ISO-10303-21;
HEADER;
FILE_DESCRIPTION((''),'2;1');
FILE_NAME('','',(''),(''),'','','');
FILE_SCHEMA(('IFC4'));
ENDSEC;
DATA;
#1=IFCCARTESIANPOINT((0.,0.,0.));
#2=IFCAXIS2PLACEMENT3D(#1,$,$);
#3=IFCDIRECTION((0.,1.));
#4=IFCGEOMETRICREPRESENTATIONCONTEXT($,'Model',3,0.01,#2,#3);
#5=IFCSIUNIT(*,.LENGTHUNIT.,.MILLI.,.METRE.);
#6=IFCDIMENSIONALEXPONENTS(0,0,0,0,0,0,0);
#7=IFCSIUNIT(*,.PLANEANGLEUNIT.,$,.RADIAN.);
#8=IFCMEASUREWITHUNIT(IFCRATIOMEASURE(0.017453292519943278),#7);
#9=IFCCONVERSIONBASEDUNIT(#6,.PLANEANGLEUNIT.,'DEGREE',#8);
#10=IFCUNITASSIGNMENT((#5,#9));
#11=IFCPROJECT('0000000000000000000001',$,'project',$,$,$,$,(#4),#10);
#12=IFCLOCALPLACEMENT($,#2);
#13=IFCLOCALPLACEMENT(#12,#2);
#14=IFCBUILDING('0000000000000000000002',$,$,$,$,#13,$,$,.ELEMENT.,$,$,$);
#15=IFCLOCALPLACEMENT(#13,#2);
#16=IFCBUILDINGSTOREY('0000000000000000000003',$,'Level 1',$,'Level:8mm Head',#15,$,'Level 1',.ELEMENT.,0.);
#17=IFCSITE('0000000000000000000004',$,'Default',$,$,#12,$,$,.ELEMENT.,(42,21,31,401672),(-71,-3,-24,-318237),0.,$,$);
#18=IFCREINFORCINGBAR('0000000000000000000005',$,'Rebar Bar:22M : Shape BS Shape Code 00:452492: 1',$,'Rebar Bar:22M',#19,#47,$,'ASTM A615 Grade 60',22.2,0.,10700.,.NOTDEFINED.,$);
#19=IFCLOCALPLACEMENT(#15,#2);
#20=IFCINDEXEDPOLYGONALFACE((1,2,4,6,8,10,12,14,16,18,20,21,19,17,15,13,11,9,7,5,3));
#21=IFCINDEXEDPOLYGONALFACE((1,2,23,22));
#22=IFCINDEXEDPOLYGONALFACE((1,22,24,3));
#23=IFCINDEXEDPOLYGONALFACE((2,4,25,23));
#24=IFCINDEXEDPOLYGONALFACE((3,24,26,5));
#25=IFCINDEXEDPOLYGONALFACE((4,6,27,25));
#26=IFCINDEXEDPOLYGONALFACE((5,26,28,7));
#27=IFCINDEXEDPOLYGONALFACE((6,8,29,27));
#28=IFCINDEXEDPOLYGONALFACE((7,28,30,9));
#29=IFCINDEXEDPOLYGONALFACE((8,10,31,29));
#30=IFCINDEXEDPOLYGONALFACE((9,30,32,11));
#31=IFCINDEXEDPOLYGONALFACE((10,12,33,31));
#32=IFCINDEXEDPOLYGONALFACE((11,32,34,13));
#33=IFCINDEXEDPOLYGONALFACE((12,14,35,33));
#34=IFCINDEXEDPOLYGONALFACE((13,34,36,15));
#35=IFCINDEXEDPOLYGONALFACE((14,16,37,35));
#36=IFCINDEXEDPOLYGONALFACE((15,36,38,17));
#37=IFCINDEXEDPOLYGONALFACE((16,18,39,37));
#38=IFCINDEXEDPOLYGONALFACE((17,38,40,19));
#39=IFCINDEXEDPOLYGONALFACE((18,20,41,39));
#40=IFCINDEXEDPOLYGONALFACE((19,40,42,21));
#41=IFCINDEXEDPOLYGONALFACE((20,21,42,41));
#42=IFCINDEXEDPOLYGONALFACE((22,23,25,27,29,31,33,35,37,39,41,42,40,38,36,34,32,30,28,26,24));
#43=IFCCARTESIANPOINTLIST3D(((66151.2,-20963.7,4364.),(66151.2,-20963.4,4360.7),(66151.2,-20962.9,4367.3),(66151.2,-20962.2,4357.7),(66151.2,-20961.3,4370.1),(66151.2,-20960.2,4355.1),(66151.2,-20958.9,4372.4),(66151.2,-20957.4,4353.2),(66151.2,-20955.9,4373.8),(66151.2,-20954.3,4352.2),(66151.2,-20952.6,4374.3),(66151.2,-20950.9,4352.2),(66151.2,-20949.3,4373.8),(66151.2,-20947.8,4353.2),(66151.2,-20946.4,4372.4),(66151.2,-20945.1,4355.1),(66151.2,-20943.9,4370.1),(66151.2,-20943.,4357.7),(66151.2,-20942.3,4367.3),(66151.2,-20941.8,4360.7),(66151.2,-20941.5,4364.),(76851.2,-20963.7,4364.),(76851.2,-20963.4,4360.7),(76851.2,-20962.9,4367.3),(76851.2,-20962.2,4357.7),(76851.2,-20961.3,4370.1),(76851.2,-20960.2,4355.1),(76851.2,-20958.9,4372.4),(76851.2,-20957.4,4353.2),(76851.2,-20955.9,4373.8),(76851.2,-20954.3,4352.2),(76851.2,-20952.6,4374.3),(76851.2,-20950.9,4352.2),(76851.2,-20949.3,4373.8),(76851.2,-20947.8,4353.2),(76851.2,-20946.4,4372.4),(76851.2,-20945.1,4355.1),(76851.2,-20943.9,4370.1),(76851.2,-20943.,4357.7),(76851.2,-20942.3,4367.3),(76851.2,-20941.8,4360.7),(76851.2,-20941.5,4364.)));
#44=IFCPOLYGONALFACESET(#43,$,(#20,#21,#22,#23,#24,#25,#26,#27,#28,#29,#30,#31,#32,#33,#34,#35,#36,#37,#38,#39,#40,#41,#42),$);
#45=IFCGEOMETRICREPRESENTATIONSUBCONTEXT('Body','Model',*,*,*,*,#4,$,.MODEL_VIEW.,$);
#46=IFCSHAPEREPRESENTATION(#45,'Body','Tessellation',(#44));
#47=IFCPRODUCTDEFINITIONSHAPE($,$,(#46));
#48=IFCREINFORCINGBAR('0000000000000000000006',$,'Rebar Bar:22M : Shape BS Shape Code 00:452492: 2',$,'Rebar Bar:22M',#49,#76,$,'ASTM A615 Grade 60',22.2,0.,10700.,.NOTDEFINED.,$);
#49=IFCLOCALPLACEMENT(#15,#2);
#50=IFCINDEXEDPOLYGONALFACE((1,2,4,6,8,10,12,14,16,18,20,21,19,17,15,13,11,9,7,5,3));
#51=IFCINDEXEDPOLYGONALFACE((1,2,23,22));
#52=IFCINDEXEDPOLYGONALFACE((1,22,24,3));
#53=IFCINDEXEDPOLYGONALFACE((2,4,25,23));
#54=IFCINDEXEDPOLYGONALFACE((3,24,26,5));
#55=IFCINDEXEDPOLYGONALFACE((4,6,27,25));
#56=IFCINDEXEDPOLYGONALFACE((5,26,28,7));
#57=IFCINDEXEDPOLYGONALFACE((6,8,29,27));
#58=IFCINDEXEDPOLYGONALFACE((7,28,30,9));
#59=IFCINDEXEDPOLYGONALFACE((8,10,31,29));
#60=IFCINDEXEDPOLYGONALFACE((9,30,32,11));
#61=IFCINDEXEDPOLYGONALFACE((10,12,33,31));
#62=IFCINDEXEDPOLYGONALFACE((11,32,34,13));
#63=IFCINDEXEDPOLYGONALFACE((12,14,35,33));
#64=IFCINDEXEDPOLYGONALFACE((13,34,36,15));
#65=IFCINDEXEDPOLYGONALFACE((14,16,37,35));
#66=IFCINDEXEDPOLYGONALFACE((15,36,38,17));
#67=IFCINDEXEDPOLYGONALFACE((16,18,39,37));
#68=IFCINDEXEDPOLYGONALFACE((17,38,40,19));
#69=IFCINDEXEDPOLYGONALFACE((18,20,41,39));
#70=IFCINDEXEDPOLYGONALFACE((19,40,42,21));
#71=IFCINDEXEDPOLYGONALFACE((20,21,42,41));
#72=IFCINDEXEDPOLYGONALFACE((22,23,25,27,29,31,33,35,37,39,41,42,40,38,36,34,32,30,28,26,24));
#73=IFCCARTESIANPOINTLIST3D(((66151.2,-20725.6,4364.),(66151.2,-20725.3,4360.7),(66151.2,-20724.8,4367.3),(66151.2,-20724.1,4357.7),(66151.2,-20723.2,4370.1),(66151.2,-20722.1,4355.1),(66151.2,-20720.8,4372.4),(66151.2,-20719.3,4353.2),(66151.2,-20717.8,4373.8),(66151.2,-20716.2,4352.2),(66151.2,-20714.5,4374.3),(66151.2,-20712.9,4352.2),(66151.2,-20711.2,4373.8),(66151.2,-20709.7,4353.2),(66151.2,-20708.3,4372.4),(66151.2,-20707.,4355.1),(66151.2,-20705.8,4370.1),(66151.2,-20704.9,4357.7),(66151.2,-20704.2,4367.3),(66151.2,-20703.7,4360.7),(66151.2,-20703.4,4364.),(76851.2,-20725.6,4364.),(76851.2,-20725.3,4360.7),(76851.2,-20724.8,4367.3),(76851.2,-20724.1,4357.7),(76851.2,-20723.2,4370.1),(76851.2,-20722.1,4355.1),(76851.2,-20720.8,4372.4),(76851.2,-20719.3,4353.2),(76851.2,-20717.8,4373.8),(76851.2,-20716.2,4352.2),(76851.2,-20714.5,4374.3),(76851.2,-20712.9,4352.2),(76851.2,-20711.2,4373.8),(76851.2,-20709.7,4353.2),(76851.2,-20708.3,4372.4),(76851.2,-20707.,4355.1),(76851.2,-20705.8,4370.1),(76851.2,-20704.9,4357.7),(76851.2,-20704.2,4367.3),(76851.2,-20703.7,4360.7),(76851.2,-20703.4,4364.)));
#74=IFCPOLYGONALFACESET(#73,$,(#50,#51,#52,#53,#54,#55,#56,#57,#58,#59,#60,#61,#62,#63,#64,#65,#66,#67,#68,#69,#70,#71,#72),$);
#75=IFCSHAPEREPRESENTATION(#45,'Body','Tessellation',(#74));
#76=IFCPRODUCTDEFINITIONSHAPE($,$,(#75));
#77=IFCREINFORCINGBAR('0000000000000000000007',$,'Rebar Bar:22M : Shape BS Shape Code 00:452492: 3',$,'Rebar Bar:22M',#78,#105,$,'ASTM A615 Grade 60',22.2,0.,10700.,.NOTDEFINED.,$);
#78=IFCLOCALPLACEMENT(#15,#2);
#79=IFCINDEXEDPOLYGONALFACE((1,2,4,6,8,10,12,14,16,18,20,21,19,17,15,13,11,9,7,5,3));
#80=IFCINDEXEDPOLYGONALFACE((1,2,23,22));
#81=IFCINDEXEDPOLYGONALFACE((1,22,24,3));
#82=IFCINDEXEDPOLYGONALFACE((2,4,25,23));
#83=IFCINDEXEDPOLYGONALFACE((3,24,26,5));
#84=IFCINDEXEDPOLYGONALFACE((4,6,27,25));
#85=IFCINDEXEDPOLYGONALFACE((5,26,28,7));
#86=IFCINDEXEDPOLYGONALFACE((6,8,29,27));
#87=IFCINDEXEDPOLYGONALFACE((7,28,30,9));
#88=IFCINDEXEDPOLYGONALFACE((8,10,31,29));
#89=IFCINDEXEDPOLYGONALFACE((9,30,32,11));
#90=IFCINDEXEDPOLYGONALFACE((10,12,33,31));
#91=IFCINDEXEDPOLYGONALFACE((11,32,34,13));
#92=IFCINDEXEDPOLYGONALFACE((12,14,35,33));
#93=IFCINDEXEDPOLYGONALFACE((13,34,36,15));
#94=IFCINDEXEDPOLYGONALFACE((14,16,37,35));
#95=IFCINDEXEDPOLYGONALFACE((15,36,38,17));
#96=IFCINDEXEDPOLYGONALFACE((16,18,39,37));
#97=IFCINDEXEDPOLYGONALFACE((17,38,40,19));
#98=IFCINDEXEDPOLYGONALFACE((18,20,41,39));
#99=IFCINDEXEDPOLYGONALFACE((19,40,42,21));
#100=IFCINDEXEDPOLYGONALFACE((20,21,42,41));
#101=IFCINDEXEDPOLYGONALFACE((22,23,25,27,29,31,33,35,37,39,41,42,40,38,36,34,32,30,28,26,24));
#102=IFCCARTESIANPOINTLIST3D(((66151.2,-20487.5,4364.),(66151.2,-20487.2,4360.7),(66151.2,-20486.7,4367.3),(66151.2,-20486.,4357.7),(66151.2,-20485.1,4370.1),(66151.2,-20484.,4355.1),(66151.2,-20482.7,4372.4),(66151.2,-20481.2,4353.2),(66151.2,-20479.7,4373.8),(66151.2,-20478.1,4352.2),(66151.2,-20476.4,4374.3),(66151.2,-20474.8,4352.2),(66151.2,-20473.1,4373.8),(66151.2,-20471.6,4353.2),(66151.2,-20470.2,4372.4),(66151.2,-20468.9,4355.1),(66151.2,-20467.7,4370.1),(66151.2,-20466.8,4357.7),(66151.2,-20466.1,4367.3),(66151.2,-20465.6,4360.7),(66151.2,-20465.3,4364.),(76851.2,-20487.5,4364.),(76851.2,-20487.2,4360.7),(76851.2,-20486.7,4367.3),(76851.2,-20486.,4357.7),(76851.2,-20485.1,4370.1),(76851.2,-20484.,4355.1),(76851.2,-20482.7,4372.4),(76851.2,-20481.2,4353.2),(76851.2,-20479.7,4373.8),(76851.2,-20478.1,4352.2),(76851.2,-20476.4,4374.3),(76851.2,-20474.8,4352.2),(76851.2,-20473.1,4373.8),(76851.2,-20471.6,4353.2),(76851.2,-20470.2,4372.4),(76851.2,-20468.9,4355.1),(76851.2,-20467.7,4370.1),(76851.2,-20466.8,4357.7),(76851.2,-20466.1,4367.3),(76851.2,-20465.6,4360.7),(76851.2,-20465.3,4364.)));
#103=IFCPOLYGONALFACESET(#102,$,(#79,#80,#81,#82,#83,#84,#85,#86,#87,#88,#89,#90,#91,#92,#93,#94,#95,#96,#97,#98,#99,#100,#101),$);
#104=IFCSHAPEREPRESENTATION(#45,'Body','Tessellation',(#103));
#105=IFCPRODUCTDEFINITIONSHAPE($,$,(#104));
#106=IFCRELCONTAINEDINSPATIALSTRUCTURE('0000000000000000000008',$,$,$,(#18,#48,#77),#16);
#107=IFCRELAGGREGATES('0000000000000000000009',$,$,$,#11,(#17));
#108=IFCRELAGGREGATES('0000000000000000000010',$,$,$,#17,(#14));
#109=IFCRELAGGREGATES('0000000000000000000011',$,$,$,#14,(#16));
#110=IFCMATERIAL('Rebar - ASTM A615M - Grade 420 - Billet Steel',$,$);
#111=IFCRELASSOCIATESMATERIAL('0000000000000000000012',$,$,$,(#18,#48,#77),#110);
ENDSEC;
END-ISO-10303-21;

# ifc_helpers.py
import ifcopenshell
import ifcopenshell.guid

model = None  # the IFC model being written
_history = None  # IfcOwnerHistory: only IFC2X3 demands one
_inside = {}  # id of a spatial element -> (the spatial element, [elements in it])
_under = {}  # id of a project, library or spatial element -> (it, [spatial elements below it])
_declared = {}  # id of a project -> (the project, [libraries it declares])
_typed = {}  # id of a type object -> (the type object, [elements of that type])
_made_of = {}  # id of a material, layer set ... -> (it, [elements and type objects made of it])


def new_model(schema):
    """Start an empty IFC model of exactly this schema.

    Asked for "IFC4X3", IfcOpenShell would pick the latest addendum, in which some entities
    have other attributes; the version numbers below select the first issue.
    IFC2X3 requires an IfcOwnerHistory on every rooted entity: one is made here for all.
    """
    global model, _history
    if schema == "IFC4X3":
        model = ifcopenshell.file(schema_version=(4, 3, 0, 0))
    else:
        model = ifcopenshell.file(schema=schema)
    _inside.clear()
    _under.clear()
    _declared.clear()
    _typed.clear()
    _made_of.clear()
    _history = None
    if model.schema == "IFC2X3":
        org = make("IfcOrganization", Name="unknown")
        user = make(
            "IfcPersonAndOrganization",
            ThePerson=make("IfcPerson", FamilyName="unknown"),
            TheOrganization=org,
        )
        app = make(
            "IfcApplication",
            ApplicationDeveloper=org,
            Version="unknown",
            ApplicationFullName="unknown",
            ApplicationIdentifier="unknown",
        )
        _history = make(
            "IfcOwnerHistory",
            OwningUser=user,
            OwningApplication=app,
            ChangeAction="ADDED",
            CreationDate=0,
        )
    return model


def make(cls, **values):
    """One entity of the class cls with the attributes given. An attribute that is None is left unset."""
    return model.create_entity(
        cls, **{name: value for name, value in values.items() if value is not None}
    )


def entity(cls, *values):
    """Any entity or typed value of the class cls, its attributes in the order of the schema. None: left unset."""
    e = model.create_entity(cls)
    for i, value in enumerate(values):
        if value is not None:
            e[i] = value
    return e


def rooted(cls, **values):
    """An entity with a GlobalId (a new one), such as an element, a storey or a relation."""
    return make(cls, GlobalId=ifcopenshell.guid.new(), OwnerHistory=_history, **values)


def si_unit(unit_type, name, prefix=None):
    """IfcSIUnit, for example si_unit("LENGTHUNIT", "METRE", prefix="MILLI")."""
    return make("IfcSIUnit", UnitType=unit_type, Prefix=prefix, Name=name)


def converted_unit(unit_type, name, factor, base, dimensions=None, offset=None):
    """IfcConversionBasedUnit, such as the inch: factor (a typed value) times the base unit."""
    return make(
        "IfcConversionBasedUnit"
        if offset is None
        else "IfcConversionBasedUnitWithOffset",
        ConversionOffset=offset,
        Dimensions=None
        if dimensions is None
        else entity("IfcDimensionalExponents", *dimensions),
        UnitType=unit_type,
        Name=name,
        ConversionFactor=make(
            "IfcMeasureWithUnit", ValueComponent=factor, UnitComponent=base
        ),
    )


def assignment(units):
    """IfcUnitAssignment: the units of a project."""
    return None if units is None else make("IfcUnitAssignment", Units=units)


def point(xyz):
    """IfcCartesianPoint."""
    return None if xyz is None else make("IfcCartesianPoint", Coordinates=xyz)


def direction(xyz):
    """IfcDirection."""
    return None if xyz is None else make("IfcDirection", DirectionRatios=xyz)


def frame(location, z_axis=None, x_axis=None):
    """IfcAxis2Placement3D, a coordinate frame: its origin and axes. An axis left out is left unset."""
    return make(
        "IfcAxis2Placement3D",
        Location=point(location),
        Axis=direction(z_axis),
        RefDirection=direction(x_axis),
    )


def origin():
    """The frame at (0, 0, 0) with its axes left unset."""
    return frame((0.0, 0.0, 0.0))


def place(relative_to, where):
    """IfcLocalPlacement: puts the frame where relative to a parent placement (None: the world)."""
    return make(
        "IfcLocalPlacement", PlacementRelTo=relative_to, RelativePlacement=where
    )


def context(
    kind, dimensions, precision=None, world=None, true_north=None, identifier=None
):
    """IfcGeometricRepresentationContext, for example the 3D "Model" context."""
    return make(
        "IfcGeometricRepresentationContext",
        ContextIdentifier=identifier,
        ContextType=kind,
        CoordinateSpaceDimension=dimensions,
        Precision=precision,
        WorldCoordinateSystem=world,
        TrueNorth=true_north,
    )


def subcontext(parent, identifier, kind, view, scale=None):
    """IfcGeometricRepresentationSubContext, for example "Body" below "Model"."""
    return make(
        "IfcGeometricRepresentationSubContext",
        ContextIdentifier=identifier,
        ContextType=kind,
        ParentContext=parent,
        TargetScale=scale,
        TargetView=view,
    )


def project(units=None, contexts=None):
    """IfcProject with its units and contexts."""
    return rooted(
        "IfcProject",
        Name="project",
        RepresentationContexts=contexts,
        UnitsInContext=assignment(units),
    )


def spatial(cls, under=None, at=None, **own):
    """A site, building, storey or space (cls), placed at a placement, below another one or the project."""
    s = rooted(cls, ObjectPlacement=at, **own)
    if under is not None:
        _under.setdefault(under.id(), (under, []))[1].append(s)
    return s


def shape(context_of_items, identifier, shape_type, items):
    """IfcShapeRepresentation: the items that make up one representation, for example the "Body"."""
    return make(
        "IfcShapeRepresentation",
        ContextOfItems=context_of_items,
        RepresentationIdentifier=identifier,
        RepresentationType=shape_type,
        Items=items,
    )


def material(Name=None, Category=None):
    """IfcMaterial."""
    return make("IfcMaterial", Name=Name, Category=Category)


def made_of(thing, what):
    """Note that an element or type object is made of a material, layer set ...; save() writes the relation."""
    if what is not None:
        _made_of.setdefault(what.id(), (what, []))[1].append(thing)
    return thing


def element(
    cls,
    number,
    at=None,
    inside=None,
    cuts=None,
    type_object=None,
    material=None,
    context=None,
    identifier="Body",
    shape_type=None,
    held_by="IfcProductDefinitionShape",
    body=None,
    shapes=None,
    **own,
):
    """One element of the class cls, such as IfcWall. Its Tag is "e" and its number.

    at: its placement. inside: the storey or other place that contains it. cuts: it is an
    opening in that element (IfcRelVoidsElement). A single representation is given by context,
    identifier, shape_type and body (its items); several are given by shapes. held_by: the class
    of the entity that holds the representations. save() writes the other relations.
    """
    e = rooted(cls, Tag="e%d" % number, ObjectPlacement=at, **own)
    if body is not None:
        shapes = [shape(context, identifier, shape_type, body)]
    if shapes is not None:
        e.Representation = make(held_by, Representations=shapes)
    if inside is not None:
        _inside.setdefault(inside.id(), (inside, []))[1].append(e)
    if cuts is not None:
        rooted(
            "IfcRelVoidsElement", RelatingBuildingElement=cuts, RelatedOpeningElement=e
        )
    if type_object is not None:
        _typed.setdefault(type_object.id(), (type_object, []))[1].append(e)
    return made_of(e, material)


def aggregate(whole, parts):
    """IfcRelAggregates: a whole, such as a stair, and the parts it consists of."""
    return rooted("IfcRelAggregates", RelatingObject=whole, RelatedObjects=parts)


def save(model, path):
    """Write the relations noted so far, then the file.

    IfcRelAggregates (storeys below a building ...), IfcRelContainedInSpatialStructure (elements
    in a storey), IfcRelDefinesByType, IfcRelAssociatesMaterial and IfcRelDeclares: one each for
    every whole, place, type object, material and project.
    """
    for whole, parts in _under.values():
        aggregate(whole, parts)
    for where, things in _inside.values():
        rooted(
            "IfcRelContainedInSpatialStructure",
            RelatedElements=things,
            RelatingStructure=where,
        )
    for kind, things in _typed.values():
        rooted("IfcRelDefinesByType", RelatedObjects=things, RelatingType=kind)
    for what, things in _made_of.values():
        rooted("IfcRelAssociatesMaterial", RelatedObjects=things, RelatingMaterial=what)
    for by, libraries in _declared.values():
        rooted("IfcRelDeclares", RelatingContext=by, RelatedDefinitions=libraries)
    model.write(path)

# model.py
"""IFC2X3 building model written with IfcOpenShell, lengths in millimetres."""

from ifc_helpers import new_model, entity, si_unit, converted_unit, direction, origin, place, context, subcontext, project, spatial, material, element, save


model = new_model("IFC2X3")

# Units and contexts
model_context = context("Model", 3, precision=0.01, world=origin(), true_north=direction((0.0, 1.0)))
body_context = subcontext(model_context, "Body", "Model", "MODEL_VIEW")
ifc_project = project(units=[si_unit("LENGTHUNIT", "METRE", prefix="MILLI"), converted_unit("PLANEANGLEUNIT", "DEGREE", entity("IfcRatioMeasure", 0.017453292519943278), si_unit("PLANEANGLEUNIT", "RADIAN"), dimensions=[0, 0, 0, 0, 0, 0, 0])], contexts=[model_context])

# Site, building, storey
site_placement = place(None, origin())
site = spatial("IfcSite", under=ifc_project, at=site_placement, Name="Default", CompositionType="ELEMENT", RefLatitude=(42, 21, 31, 401672), RefLongitude=(-71, -3, -24, -318237), RefElevation=0.0)
building_placement = place(site_placement, origin())
building = spatial("IfcBuilding", under=site, at=building_placement, CompositionType="ELEMENT")
storey_placement = place(building_placement, origin())
storey = spatial("IfcBuildingStorey", under=building, at=storey_placement, Name="Level 1", ObjectType="Level:8mm Head", LongName="Level 1", CompositionType="ELEMENT", Elevation=0.0)

# Reinforcing bars
ifc_material = material(Name="Rebar - ASTM A615M - Grade 420 - Billet Steel")
reinforcing_bar_1_placement = place(storey_placement, origin())
element("IfcReinforcingBar", 1, at=reinforcing_bar_1_placement, inside=storey, material=ifc_material, Name="Rebar Bar:22M : Shape BS Shape Code 00:452492: 1", SteelGrade="ASTM A615 Grade 60", ObjectType="Rebar Bar:22M", BarLength=10700.0, BarRole="NOTDEFINED", CrossSectionArea=0.0, NominalDiameter=22.2, context=body_context, shape_type="AdvancedSweptSolid", body=[
    entity("IfcSweptDiskSolid", entity("IfcCompositeCurve", [entity("IfcCompositeCurveSegment", "CONTINUOUS", True, entity("IfcPolyline", [entity("IfcCartesianPoint", [66151.2, -20952.6, 4363.2]), entity("IfcCartesianPoint", [76851.2, -20952.6, 4363.2])]))], False), 11.1, None, 0.0, 1.0),
])
reinforcing_bar_2_placement = place(storey_placement, origin())
element("IfcReinforcingBar", 2, at=reinforcing_bar_2_placement, inside=storey, material=ifc_material, Name="Rebar Bar:22M : Shape BS Shape Code 00:452492: 2", SteelGrade="ASTM A615 Grade 60", ObjectType="Rebar Bar:22M", BarLength=10700.0, BarRole="NOTDEFINED", CrossSectionArea=0.0, NominalDiameter=22.2, context=body_context, shape_type="AdvancedSweptSolid", body=[
    entity("IfcSweptDiskSolid", entity("IfcCompositeCurve", [entity("IfcCompositeCurveSegment", "CONTINUOUS", True, entity("IfcPolyline", [entity("IfcCartesianPoint", [66151.2, -20714.5, 4363.2]), entity("IfcCartesianPoint", [76851.2, -20714.5, 4363.2])]))], False), 11.1, None, 0.0, 1.0),
])
reinforcing_bar_3_placement = place(storey_placement, origin())
element("IfcReinforcingBar", 3, at=reinforcing_bar_3_placement, inside=storey, material=ifc_material, Name="Rebar Bar:22M : Shape BS Shape Code 00:452492: 3", SteelGrade="ASTM A615 Grade 60", ObjectType="Rebar Bar:22M", BarLength=10700.0, BarRole="NOTDEFINED", CrossSectionArea=0.0, NominalDiameter=22.2, context=body_context, shape_type="AdvancedSweptSolid", body=[
    entity("IfcSweptDiskSolid", entity("IfcCompositeCurve", [entity("IfcCompositeCurveSegment", "CONTINUOUS", True, entity("IfcPolyline", [entity("IfcCartesianPoint", [66151.2, -20476.4, 4363.2]), entity("IfcCartesianPoint", [76851.2, -20476.4, 4363.2])]))], False), 11.1, None, 0.0, 1.0),
])

save(model, "model.ifc")
